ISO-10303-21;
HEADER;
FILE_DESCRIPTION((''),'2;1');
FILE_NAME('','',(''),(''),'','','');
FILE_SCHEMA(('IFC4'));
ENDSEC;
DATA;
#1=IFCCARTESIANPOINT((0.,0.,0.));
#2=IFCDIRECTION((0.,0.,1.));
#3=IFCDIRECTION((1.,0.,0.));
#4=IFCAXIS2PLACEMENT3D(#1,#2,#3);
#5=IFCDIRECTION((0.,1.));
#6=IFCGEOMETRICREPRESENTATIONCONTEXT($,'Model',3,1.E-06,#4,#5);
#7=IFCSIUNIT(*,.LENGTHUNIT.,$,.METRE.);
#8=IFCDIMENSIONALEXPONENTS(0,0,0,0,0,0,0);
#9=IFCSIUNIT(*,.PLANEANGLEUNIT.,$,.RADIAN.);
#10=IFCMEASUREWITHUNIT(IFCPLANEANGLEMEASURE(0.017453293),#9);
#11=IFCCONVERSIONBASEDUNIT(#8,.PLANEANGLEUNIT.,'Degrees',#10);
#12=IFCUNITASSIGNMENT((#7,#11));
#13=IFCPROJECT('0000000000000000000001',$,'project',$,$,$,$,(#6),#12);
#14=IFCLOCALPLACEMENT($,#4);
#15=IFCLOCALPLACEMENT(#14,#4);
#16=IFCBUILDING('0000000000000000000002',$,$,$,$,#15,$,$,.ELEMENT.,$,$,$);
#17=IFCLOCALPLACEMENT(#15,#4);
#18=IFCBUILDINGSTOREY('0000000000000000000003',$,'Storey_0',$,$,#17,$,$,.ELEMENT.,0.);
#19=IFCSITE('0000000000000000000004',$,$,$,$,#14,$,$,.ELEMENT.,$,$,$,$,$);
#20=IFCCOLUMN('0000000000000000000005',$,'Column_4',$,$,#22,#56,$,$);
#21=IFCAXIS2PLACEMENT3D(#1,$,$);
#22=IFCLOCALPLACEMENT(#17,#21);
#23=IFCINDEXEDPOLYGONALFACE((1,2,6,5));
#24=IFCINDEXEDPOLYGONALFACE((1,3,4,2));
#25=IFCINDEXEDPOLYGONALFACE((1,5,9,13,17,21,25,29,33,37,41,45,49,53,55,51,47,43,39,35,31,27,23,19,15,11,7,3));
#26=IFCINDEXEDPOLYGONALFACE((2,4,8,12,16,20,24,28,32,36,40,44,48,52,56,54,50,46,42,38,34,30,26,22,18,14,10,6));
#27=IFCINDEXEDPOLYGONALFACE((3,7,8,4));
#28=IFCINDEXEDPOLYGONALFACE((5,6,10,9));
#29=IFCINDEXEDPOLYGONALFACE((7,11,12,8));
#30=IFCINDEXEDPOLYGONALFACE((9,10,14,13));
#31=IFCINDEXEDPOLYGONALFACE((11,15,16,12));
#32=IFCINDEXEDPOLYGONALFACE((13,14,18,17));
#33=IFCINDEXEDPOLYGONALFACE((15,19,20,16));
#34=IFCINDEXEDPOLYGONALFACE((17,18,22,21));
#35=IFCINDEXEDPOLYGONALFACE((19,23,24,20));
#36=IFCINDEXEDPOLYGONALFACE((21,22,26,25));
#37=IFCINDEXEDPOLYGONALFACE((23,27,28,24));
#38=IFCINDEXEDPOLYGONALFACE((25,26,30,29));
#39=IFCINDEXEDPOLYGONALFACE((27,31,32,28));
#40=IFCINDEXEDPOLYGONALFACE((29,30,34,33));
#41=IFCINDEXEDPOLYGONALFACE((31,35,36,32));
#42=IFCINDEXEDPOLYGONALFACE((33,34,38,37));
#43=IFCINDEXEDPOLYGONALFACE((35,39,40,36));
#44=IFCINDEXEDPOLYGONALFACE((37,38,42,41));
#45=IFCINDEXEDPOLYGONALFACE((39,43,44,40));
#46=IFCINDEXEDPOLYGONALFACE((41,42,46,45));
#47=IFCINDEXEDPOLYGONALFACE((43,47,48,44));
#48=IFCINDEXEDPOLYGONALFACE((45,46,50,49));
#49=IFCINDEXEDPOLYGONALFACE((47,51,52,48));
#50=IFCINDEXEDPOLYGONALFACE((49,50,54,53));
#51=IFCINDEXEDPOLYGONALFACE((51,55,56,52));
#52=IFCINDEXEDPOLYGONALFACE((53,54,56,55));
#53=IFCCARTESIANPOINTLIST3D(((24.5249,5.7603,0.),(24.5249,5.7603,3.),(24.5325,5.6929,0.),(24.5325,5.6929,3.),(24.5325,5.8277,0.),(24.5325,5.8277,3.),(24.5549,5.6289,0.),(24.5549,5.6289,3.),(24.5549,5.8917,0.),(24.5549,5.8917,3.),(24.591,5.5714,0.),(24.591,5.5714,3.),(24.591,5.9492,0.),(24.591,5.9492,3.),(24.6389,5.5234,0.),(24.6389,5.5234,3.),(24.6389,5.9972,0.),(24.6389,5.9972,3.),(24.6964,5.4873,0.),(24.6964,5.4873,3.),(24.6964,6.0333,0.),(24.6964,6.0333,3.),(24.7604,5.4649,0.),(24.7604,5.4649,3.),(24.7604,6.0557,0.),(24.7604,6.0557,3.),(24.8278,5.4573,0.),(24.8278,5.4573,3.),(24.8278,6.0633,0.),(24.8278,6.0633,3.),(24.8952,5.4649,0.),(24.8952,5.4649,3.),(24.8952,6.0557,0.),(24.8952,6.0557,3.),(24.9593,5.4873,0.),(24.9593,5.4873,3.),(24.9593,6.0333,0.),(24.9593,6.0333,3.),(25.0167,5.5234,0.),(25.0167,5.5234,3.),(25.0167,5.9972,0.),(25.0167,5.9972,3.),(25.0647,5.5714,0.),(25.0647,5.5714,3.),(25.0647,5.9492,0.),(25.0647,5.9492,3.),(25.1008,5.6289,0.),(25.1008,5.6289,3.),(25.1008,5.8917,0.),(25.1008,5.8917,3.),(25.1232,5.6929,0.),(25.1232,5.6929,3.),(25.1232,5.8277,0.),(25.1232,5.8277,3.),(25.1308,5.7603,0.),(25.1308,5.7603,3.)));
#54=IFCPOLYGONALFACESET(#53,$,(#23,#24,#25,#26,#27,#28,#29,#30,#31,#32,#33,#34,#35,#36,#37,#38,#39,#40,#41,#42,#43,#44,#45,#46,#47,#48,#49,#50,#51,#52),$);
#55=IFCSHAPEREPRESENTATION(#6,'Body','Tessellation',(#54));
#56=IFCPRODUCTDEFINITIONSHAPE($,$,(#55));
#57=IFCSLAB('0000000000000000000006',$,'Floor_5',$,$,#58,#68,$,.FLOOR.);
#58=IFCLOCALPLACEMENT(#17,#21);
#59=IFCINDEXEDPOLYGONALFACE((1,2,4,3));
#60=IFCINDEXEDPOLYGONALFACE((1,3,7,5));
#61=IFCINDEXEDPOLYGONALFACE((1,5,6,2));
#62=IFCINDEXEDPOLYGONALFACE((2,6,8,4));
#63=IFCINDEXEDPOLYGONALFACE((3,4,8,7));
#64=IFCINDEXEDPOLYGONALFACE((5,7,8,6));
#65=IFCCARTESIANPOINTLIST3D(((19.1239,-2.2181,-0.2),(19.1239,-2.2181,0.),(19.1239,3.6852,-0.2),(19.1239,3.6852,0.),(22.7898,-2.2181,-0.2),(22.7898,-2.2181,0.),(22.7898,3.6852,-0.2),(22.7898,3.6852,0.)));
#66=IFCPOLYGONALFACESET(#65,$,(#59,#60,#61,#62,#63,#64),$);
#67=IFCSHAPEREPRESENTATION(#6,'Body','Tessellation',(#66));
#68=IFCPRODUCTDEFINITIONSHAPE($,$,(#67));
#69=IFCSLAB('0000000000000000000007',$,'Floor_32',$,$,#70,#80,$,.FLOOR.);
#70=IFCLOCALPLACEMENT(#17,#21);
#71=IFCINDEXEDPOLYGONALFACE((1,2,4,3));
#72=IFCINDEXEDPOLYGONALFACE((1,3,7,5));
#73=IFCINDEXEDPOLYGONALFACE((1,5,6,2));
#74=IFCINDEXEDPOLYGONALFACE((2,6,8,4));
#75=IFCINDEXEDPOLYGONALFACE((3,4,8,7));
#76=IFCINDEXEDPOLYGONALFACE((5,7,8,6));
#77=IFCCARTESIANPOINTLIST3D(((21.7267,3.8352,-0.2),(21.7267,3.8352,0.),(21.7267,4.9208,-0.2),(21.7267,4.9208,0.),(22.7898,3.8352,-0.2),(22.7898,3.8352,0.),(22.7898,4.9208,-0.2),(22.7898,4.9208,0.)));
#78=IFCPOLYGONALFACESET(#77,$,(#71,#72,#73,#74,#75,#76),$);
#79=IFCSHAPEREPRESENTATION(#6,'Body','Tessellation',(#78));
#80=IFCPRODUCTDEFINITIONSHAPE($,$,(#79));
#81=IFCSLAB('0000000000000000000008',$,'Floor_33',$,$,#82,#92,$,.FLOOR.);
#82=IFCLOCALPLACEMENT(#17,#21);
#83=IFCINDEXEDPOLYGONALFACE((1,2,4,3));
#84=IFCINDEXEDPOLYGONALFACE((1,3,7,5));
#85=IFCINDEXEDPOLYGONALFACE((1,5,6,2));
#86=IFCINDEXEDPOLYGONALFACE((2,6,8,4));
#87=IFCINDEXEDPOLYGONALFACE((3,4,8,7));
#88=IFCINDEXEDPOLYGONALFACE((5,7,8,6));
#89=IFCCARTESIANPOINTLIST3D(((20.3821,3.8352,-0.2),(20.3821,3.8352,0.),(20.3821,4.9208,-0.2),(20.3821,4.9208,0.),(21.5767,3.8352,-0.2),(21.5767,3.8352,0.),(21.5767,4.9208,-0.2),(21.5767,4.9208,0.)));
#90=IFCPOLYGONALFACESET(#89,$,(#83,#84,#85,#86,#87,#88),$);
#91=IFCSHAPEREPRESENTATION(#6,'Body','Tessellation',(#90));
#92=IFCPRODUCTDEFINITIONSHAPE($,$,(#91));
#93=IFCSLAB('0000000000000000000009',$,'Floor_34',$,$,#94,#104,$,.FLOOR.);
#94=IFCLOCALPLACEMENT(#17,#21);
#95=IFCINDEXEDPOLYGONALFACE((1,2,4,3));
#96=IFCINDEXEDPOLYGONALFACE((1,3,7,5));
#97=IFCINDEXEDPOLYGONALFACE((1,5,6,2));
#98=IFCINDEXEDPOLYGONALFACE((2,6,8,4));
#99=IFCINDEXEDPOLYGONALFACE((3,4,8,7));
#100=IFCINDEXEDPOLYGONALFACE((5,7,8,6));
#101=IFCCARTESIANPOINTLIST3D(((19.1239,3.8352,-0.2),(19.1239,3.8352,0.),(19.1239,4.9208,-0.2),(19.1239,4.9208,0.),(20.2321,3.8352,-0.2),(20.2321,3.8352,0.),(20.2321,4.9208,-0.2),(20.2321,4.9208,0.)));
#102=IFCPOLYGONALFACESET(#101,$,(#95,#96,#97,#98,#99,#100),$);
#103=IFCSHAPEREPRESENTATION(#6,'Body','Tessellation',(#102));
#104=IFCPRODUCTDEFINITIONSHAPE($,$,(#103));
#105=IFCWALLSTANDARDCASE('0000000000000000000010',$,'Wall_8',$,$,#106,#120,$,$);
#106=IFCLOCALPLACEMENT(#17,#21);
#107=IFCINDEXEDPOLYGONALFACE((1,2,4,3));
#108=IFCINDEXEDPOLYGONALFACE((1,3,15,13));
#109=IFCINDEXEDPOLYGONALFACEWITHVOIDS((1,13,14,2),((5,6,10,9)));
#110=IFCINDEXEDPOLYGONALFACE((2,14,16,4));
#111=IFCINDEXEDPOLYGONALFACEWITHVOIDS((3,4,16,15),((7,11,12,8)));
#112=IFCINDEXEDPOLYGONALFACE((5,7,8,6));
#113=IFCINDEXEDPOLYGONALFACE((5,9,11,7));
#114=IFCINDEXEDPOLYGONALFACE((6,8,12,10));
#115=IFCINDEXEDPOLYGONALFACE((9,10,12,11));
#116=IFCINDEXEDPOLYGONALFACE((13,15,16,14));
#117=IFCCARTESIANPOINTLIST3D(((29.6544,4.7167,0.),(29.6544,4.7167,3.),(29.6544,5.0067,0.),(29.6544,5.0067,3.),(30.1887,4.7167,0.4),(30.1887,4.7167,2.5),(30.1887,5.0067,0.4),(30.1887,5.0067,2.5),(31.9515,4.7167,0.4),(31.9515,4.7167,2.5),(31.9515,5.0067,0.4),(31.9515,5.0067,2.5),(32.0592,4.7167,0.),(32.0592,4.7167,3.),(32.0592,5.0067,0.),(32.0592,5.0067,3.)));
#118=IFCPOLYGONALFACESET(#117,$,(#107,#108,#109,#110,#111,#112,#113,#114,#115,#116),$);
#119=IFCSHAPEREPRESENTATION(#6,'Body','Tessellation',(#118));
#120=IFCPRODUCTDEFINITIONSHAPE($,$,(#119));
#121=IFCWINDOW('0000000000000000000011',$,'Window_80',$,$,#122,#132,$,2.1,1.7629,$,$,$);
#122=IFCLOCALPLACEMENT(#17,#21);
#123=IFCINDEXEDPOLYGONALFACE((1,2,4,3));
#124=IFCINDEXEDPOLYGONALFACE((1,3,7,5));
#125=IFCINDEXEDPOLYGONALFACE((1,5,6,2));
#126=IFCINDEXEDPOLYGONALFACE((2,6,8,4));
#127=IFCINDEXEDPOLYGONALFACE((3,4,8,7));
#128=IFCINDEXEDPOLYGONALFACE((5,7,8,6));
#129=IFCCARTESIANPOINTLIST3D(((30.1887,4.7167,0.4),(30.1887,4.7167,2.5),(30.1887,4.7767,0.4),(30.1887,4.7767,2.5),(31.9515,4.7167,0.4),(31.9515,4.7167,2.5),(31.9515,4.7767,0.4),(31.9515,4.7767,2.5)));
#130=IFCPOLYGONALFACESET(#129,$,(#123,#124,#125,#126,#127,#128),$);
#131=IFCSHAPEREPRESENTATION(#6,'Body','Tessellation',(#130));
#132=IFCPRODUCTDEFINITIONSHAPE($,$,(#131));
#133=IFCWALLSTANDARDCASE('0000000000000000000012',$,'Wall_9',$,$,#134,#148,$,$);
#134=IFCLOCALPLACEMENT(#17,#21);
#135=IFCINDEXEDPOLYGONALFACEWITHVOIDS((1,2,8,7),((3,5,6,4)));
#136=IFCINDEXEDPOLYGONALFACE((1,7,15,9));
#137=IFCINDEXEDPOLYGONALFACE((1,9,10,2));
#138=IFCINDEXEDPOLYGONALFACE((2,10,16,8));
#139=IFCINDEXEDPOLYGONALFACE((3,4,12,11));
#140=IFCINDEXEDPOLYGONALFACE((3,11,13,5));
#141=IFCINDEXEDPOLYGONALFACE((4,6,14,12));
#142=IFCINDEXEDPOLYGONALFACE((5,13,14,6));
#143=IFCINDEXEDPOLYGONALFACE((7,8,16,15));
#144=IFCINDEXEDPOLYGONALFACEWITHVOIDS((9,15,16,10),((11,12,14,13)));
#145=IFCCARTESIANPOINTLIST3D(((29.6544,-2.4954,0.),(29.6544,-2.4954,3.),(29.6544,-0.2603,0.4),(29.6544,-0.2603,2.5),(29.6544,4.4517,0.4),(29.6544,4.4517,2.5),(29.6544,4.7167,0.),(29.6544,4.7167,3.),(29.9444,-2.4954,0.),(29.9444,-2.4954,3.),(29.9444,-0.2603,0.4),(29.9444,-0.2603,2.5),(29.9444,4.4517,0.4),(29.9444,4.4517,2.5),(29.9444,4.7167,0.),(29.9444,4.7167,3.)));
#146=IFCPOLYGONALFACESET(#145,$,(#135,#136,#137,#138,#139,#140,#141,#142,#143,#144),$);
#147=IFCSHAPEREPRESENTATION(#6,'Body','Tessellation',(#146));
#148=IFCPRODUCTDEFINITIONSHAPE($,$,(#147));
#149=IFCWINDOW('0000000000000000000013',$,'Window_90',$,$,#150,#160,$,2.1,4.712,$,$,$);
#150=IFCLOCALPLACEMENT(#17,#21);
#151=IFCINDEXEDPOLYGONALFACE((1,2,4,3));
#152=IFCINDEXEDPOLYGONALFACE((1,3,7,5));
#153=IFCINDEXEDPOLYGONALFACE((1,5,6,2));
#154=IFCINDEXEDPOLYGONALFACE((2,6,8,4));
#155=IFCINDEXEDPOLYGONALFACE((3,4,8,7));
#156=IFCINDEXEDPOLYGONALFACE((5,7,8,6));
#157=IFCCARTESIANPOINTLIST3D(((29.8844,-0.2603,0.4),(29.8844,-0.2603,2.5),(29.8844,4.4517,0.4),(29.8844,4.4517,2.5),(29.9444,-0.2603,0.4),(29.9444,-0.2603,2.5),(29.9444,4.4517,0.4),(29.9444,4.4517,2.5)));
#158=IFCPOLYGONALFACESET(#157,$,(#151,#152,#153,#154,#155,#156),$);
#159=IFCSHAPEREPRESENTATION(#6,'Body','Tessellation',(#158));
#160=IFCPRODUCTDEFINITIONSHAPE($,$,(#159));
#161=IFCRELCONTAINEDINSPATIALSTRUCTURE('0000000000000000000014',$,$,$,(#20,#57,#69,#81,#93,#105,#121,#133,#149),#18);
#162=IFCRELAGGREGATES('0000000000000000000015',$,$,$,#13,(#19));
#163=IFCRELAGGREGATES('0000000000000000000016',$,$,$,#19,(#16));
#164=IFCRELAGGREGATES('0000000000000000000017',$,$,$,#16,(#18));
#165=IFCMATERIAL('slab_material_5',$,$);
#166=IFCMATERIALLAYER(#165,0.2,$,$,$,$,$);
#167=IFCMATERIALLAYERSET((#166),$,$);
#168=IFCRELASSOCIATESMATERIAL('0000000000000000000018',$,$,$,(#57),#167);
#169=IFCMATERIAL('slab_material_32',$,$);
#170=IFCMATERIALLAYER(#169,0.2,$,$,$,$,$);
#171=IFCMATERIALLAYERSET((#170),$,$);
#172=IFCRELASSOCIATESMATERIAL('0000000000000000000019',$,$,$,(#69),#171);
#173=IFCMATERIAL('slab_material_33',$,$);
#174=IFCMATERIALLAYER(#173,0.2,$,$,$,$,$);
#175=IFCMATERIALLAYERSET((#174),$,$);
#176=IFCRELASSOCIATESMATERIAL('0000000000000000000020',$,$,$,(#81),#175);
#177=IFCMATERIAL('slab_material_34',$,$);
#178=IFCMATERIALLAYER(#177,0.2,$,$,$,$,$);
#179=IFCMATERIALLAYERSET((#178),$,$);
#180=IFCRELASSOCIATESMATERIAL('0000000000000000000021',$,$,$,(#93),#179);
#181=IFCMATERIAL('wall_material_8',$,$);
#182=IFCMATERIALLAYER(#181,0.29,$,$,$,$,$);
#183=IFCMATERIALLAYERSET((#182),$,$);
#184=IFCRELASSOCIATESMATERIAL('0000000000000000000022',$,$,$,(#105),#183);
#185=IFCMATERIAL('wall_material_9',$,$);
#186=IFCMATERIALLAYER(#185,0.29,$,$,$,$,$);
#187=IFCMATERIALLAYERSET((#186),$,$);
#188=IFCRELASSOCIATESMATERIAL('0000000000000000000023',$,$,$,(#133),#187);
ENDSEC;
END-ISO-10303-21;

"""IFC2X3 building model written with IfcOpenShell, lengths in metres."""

from ifc_helpers import new_model, entity, si_unit, converted_unit, direction, frame, frame_2d, origin_with_axes, origin_2d_with_axis, place, context, project, spatial, polyline, rectangle, circle, outline, extrude, material, layer, layer_set, layer_usage, element, fill, save


model = new_model("IFC2X3")

# Units and contexts
model_context = context("Model", 3, precision=1e-06, world=origin_with_axes(), true_north=direction((0.0, 1.0)))
ifc_project = project(units=[si_unit("LENGTHUNIT", "METRE"), converted_unit("PLANEANGLEUNIT", "Degrees", entity("IfcPlaneAngleMeasure", 0.017453293), si_unit("PLANEANGLEUNIT", "RADIAN"), dimensions=[0, 0, 0, 0, 0, 0, 0])], contexts=[model_context])

# Site, building, storey
site_placement = place(None, origin_with_axes())
site = spatial("IfcSite", under=ifc_project, at=site_placement, CompositionType="ELEMENT")
building_placement = place(site_placement, origin_with_axes())
building = spatial("IfcBuilding", under=site, at=building_placement, CompositionType="ELEMENT")
storey_placement = place(building_placement, origin_with_axes())
storey = spatial("IfcBuildingStorey", under=building, at=storey_placement, Name="Storey_0", CompositionType="ELEMENT", Elevation=0.0)

# Column
column_placement = place(storey_placement, frame((24.8278, 5.7603, 0.0), z_axis=(0.0, 0.0, 1.0), x_axis=(1.0, 0.0, 0.0)))
element("IfcColumn", 1, at=column_placement, inside=storey, Name="Column_4", context=model_context, shape_type="SweptSolid", body=[
    extrude(circle(Radius=0.303, at=origin_2d_with_axis()), origin_with_axes(), (0.0, 0.0, 1.0), 3.0),
])

# Slabs
ifc_material_1 = material(Name="slab_material_5")
ifc_layer_1 = layer(ifc_material_1, 0.2)
ifc_layer_set_1 = layer_set([ifc_layer_1])
ifc_layer_usage_1 = layer_usage(ifc_layer_set_1, "AXIS3", "POSITIVE", 0.0)
slab_1_placement = place(storey_placement, frame((20.9569, 0.7336, -0.2), z_axis=(0.0, 0.0, 1.0), x_axis=(1.0, 0.0, 0.0)))
element("IfcSlab", 2, at=slab_1_placement, inside=storey, material=ifc_layer_usage_1, Name="Floor_5", PredefinedType="FLOOR", context=model_context, shape_type="SweptSolid", body=[
    extrude(outline(polyline([(1.8329, 2.9517), (1.8329, -2.9517), (-1.8329, -2.9517), (-1.8329, 2.9517), (1.8329, 2.9517)])), origin_with_axes(), (0.0, 0.0, 1.0), 0.2),
])
ifc_material_2 = material(Name="slab_material_32")
ifc_layer_2 = layer(ifc_material_2, 0.2)
ifc_layer_set_2 = layer_set([ifc_layer_2])
ifc_layer_usage_2 = layer_usage(ifc_layer_set_2, "AXIS3", "POSITIVE", 0.0)
slab_2_placement = place(storey_placement, frame((22.2582, 4.378, -0.2), z_axis=(0.0, 0.0, 1.0), x_axis=(1.0, 0.0, 0.0)))
element("IfcSlab", 3, at=slab_2_placement, inside=storey, material=ifc_layer_usage_2, Name="Floor_32", PredefinedType="FLOOR", context=model_context, shape_type="SweptSolid", body=[
    extrude(outline(polyline([(0.5316, -0.5428), (-0.5316, -0.5428), (-0.5316, 0.5428), (0.5316, 0.5428), (0.5316, -0.5428)])), origin_with_axes(), (0.0, 0.0, 1.0), 0.2),
])
ifc_material_3 = material(Name="slab_material_33")
ifc_layer_3 = layer(ifc_material_3, 0.2)
ifc_layer_set_3 = layer_set([ifc_layer_3])
ifc_layer_usage_3 = layer_usage(ifc_layer_set_3, "AXIS3", "POSITIVE", 0.0)
slab_3_placement = place(storey_placement, frame((20.9794, 4.378, -0.2), z_axis=(0.0, 0.0, 1.0), x_axis=(1.0, 0.0, 0.0)))
element("IfcSlab", 4, at=slab_3_placement, inside=storey, material=ifc_layer_usage_3, Name="Floor_33", PredefinedType="FLOOR", context=model_context, shape_type="SweptSolid", body=[
    extrude(outline(polyline([(0.5973, -0.5428), (-0.5973, -0.5428), (-0.5973, 0.5428), (0.5973, 0.5428), (0.5973, -0.5428)])), origin_with_axes(), (0.0, 0.0, 1.0), 0.2),
])
ifc_material_4 = material(Name="slab_material_34")
ifc_layer_4 = layer(ifc_material_4, 0.2)
ifc_layer_set_4 = layer_set([ifc_layer_4])
ifc_layer_usage_4 = layer_usage(ifc_layer_set_4, "AXIS3", "POSITIVE", 0.0)
slab_4_placement = place(storey_placement, frame((19.678, 4.378, -0.2), z_axis=(0.0, 0.0, 1.0), x_axis=(1.0, 0.0, 0.0)))
element("IfcSlab", 5, at=slab_4_placement, inside=storey, material=ifc_layer_usage_4, Name="Floor_34", PredefinedType="FLOOR", context=model_context, shape_type="SweptSolid", body=[
    extrude(outline(polyline([(0.5541, -0.5428), (-0.5541, -0.5428), (-0.5541, 0.5428), (0.5541, 0.5428), (0.5541, -0.5428)])), origin_with_axes(), (0.0, 0.0, 1.0), 0.2),
])

# Walls, openings, windows
ifc_material_5 = material(Name="wall_material_8")
ifc_layer_5 = layer(ifc_material_5, 0.29)
ifc_layer_set_5 = layer_set([ifc_layer_5])
ifc_layer_usage_5 = layer_usage(ifc_layer_set_5, "AXIS2", "POSITIVE", 0.0)
wall_1_placement = place(storey_placement, frame((32.0592, 5.0067, 0.0), z_axis=(0.0, 0.0, 1.0), x_axis=(-1.0, 0.0, 0.0)))
wall_1 = element("IfcWallStandardCase", 6, at=wall_1_placement, inside=storey, material=ifc_layer_usage_5, Name="Wall_8", context=model_context, shape_type="SweptSolid", body=[
    extrude(outline(polyline([(0.0, 0.29), (2.4048, 0.29), (2.4048, 0.0), (0.0, 0.0), (0.0, 0.29)])), origin_with_axes(), (0.0, 0.0, 1.0), 3.0),
])
opening_1_placement = place(wall_1_placement, frame((0.1076, 0.29, 0.4), z_axis=(0.0, 0.0, 1.0), x_axis=(1.0, 0.0, 0.0)))
opening_1 = element("IfcOpeningElement", 7, at=opening_1_placement, cuts=wall_1, context=model_context, shape_type="SweptSolid", body=[
    extrude(rectangle(XDim=1.7629, YDim=2.1, at=frame_2d((1.05, -0.8814), x_axis=(0.0, 1.0))), frame((0.0, 0.01, 0.0), z_axis=(0.0, -1.0, 0.0), x_axis=(0.0, 0.0, 1.0)), (0.0, 0.0, 1.0), 0.31),
])
window_1_placement = place(storey_placement, frame((0.0, 0.0, 0.4), z_axis=(0.0, 0.0, 1.0), x_axis=(1.0, 0.0, 0.0)))
window_1 = element("IfcWindow", 8, at=window_1_placement, inside=storey, Name="Window_80", OverallHeight=2.1, OverallWidth=1.7629, context=model_context, shape_type="SweptSolid", body=[
    extrude(outline(polyline([(31.9515, 4.7167), (30.1887, 4.7167), (30.1887, 4.7767), (31.9515, 4.7767), (31.9515, 4.7167)])), origin_with_axes(), (0.0, 0.0, 1.0), 2.1),
])
fill(opening_1, window_1)
ifc_material_6 = material(Name="wall_material_9")
ifc_layer_6 = layer(ifc_material_6, 0.29)
ifc_layer_set_6 = layer_set([ifc_layer_6])
ifc_layer_usage_6 = layer_usage(ifc_layer_set_6, "AXIS2", "NEGATIVE", 0.0)
wall_2_placement = place(storey_placement, frame((29.9444, 4.7167, 0.0), z_axis=(0.0, 0.0, 1.0), x_axis=(0.0, -1.0, 0.0)))
wall_2 = element("IfcWallStandardCase", 9, at=wall_2_placement, inside=storey, material=ifc_layer_usage_6, Name="Wall_9", context=model_context, shape_type="SweptSolid", body=[
    extrude(outline(polyline([(0.0, 0.0), (7.2121, 0.0), (7.2121, -0.29), (0.0, -0.29), (0.0, 0.0)])), origin_with_axes(), (0.0, 0.0, 1.0), 3.0),
])
opening_2_placement = place(wall_2_placement, frame((0.265, 0.0, 0.4), z_axis=(0.0, 0.0, 1.0), x_axis=(1.0, 0.0, 0.0)))
opening_2 = element("IfcOpeningElement", 10, at=opening_2_placement, cuts=wall_2, context=model_context, shape_type="SweptSolid", body=[
    extrude(rectangle(XDim=4.712, YDim=2.1, at=frame_2d((1.05, -2.356), x_axis=(0.0, 1.0))), frame((0.0, 0.01, 0.0), z_axis=(0.0, -1.0, 0.0), x_axis=(0.0, 0.0, 1.0)), (0.0, 0.0, 1.0), 0.31),
])
window_2_placement = place(storey_placement, frame((0.0, 0.0, 0.4), z_axis=(0.0, 0.0, 1.0), x_axis=(1.0, 0.0, 0.0)))
window_2 = element("IfcWindow", 11, at=window_2_placement, inside=storey, Name="Window_90", OverallHeight=2.1, OverallWidth=4.712, context=model_context, shape_type="SweptSolid", body=[
    extrude(outline(polyline([(29.9444, 4.4517), (29.9444, -0.2603), (29.8844, -0.2603), (29.8844, 4.4517), (29.9444, 4.4517)])), origin_with_axes(), (0.0, 0.0, 1.0), 2.1),
])
fill(opening_2, window_2)

save(model, "model.ifc")
